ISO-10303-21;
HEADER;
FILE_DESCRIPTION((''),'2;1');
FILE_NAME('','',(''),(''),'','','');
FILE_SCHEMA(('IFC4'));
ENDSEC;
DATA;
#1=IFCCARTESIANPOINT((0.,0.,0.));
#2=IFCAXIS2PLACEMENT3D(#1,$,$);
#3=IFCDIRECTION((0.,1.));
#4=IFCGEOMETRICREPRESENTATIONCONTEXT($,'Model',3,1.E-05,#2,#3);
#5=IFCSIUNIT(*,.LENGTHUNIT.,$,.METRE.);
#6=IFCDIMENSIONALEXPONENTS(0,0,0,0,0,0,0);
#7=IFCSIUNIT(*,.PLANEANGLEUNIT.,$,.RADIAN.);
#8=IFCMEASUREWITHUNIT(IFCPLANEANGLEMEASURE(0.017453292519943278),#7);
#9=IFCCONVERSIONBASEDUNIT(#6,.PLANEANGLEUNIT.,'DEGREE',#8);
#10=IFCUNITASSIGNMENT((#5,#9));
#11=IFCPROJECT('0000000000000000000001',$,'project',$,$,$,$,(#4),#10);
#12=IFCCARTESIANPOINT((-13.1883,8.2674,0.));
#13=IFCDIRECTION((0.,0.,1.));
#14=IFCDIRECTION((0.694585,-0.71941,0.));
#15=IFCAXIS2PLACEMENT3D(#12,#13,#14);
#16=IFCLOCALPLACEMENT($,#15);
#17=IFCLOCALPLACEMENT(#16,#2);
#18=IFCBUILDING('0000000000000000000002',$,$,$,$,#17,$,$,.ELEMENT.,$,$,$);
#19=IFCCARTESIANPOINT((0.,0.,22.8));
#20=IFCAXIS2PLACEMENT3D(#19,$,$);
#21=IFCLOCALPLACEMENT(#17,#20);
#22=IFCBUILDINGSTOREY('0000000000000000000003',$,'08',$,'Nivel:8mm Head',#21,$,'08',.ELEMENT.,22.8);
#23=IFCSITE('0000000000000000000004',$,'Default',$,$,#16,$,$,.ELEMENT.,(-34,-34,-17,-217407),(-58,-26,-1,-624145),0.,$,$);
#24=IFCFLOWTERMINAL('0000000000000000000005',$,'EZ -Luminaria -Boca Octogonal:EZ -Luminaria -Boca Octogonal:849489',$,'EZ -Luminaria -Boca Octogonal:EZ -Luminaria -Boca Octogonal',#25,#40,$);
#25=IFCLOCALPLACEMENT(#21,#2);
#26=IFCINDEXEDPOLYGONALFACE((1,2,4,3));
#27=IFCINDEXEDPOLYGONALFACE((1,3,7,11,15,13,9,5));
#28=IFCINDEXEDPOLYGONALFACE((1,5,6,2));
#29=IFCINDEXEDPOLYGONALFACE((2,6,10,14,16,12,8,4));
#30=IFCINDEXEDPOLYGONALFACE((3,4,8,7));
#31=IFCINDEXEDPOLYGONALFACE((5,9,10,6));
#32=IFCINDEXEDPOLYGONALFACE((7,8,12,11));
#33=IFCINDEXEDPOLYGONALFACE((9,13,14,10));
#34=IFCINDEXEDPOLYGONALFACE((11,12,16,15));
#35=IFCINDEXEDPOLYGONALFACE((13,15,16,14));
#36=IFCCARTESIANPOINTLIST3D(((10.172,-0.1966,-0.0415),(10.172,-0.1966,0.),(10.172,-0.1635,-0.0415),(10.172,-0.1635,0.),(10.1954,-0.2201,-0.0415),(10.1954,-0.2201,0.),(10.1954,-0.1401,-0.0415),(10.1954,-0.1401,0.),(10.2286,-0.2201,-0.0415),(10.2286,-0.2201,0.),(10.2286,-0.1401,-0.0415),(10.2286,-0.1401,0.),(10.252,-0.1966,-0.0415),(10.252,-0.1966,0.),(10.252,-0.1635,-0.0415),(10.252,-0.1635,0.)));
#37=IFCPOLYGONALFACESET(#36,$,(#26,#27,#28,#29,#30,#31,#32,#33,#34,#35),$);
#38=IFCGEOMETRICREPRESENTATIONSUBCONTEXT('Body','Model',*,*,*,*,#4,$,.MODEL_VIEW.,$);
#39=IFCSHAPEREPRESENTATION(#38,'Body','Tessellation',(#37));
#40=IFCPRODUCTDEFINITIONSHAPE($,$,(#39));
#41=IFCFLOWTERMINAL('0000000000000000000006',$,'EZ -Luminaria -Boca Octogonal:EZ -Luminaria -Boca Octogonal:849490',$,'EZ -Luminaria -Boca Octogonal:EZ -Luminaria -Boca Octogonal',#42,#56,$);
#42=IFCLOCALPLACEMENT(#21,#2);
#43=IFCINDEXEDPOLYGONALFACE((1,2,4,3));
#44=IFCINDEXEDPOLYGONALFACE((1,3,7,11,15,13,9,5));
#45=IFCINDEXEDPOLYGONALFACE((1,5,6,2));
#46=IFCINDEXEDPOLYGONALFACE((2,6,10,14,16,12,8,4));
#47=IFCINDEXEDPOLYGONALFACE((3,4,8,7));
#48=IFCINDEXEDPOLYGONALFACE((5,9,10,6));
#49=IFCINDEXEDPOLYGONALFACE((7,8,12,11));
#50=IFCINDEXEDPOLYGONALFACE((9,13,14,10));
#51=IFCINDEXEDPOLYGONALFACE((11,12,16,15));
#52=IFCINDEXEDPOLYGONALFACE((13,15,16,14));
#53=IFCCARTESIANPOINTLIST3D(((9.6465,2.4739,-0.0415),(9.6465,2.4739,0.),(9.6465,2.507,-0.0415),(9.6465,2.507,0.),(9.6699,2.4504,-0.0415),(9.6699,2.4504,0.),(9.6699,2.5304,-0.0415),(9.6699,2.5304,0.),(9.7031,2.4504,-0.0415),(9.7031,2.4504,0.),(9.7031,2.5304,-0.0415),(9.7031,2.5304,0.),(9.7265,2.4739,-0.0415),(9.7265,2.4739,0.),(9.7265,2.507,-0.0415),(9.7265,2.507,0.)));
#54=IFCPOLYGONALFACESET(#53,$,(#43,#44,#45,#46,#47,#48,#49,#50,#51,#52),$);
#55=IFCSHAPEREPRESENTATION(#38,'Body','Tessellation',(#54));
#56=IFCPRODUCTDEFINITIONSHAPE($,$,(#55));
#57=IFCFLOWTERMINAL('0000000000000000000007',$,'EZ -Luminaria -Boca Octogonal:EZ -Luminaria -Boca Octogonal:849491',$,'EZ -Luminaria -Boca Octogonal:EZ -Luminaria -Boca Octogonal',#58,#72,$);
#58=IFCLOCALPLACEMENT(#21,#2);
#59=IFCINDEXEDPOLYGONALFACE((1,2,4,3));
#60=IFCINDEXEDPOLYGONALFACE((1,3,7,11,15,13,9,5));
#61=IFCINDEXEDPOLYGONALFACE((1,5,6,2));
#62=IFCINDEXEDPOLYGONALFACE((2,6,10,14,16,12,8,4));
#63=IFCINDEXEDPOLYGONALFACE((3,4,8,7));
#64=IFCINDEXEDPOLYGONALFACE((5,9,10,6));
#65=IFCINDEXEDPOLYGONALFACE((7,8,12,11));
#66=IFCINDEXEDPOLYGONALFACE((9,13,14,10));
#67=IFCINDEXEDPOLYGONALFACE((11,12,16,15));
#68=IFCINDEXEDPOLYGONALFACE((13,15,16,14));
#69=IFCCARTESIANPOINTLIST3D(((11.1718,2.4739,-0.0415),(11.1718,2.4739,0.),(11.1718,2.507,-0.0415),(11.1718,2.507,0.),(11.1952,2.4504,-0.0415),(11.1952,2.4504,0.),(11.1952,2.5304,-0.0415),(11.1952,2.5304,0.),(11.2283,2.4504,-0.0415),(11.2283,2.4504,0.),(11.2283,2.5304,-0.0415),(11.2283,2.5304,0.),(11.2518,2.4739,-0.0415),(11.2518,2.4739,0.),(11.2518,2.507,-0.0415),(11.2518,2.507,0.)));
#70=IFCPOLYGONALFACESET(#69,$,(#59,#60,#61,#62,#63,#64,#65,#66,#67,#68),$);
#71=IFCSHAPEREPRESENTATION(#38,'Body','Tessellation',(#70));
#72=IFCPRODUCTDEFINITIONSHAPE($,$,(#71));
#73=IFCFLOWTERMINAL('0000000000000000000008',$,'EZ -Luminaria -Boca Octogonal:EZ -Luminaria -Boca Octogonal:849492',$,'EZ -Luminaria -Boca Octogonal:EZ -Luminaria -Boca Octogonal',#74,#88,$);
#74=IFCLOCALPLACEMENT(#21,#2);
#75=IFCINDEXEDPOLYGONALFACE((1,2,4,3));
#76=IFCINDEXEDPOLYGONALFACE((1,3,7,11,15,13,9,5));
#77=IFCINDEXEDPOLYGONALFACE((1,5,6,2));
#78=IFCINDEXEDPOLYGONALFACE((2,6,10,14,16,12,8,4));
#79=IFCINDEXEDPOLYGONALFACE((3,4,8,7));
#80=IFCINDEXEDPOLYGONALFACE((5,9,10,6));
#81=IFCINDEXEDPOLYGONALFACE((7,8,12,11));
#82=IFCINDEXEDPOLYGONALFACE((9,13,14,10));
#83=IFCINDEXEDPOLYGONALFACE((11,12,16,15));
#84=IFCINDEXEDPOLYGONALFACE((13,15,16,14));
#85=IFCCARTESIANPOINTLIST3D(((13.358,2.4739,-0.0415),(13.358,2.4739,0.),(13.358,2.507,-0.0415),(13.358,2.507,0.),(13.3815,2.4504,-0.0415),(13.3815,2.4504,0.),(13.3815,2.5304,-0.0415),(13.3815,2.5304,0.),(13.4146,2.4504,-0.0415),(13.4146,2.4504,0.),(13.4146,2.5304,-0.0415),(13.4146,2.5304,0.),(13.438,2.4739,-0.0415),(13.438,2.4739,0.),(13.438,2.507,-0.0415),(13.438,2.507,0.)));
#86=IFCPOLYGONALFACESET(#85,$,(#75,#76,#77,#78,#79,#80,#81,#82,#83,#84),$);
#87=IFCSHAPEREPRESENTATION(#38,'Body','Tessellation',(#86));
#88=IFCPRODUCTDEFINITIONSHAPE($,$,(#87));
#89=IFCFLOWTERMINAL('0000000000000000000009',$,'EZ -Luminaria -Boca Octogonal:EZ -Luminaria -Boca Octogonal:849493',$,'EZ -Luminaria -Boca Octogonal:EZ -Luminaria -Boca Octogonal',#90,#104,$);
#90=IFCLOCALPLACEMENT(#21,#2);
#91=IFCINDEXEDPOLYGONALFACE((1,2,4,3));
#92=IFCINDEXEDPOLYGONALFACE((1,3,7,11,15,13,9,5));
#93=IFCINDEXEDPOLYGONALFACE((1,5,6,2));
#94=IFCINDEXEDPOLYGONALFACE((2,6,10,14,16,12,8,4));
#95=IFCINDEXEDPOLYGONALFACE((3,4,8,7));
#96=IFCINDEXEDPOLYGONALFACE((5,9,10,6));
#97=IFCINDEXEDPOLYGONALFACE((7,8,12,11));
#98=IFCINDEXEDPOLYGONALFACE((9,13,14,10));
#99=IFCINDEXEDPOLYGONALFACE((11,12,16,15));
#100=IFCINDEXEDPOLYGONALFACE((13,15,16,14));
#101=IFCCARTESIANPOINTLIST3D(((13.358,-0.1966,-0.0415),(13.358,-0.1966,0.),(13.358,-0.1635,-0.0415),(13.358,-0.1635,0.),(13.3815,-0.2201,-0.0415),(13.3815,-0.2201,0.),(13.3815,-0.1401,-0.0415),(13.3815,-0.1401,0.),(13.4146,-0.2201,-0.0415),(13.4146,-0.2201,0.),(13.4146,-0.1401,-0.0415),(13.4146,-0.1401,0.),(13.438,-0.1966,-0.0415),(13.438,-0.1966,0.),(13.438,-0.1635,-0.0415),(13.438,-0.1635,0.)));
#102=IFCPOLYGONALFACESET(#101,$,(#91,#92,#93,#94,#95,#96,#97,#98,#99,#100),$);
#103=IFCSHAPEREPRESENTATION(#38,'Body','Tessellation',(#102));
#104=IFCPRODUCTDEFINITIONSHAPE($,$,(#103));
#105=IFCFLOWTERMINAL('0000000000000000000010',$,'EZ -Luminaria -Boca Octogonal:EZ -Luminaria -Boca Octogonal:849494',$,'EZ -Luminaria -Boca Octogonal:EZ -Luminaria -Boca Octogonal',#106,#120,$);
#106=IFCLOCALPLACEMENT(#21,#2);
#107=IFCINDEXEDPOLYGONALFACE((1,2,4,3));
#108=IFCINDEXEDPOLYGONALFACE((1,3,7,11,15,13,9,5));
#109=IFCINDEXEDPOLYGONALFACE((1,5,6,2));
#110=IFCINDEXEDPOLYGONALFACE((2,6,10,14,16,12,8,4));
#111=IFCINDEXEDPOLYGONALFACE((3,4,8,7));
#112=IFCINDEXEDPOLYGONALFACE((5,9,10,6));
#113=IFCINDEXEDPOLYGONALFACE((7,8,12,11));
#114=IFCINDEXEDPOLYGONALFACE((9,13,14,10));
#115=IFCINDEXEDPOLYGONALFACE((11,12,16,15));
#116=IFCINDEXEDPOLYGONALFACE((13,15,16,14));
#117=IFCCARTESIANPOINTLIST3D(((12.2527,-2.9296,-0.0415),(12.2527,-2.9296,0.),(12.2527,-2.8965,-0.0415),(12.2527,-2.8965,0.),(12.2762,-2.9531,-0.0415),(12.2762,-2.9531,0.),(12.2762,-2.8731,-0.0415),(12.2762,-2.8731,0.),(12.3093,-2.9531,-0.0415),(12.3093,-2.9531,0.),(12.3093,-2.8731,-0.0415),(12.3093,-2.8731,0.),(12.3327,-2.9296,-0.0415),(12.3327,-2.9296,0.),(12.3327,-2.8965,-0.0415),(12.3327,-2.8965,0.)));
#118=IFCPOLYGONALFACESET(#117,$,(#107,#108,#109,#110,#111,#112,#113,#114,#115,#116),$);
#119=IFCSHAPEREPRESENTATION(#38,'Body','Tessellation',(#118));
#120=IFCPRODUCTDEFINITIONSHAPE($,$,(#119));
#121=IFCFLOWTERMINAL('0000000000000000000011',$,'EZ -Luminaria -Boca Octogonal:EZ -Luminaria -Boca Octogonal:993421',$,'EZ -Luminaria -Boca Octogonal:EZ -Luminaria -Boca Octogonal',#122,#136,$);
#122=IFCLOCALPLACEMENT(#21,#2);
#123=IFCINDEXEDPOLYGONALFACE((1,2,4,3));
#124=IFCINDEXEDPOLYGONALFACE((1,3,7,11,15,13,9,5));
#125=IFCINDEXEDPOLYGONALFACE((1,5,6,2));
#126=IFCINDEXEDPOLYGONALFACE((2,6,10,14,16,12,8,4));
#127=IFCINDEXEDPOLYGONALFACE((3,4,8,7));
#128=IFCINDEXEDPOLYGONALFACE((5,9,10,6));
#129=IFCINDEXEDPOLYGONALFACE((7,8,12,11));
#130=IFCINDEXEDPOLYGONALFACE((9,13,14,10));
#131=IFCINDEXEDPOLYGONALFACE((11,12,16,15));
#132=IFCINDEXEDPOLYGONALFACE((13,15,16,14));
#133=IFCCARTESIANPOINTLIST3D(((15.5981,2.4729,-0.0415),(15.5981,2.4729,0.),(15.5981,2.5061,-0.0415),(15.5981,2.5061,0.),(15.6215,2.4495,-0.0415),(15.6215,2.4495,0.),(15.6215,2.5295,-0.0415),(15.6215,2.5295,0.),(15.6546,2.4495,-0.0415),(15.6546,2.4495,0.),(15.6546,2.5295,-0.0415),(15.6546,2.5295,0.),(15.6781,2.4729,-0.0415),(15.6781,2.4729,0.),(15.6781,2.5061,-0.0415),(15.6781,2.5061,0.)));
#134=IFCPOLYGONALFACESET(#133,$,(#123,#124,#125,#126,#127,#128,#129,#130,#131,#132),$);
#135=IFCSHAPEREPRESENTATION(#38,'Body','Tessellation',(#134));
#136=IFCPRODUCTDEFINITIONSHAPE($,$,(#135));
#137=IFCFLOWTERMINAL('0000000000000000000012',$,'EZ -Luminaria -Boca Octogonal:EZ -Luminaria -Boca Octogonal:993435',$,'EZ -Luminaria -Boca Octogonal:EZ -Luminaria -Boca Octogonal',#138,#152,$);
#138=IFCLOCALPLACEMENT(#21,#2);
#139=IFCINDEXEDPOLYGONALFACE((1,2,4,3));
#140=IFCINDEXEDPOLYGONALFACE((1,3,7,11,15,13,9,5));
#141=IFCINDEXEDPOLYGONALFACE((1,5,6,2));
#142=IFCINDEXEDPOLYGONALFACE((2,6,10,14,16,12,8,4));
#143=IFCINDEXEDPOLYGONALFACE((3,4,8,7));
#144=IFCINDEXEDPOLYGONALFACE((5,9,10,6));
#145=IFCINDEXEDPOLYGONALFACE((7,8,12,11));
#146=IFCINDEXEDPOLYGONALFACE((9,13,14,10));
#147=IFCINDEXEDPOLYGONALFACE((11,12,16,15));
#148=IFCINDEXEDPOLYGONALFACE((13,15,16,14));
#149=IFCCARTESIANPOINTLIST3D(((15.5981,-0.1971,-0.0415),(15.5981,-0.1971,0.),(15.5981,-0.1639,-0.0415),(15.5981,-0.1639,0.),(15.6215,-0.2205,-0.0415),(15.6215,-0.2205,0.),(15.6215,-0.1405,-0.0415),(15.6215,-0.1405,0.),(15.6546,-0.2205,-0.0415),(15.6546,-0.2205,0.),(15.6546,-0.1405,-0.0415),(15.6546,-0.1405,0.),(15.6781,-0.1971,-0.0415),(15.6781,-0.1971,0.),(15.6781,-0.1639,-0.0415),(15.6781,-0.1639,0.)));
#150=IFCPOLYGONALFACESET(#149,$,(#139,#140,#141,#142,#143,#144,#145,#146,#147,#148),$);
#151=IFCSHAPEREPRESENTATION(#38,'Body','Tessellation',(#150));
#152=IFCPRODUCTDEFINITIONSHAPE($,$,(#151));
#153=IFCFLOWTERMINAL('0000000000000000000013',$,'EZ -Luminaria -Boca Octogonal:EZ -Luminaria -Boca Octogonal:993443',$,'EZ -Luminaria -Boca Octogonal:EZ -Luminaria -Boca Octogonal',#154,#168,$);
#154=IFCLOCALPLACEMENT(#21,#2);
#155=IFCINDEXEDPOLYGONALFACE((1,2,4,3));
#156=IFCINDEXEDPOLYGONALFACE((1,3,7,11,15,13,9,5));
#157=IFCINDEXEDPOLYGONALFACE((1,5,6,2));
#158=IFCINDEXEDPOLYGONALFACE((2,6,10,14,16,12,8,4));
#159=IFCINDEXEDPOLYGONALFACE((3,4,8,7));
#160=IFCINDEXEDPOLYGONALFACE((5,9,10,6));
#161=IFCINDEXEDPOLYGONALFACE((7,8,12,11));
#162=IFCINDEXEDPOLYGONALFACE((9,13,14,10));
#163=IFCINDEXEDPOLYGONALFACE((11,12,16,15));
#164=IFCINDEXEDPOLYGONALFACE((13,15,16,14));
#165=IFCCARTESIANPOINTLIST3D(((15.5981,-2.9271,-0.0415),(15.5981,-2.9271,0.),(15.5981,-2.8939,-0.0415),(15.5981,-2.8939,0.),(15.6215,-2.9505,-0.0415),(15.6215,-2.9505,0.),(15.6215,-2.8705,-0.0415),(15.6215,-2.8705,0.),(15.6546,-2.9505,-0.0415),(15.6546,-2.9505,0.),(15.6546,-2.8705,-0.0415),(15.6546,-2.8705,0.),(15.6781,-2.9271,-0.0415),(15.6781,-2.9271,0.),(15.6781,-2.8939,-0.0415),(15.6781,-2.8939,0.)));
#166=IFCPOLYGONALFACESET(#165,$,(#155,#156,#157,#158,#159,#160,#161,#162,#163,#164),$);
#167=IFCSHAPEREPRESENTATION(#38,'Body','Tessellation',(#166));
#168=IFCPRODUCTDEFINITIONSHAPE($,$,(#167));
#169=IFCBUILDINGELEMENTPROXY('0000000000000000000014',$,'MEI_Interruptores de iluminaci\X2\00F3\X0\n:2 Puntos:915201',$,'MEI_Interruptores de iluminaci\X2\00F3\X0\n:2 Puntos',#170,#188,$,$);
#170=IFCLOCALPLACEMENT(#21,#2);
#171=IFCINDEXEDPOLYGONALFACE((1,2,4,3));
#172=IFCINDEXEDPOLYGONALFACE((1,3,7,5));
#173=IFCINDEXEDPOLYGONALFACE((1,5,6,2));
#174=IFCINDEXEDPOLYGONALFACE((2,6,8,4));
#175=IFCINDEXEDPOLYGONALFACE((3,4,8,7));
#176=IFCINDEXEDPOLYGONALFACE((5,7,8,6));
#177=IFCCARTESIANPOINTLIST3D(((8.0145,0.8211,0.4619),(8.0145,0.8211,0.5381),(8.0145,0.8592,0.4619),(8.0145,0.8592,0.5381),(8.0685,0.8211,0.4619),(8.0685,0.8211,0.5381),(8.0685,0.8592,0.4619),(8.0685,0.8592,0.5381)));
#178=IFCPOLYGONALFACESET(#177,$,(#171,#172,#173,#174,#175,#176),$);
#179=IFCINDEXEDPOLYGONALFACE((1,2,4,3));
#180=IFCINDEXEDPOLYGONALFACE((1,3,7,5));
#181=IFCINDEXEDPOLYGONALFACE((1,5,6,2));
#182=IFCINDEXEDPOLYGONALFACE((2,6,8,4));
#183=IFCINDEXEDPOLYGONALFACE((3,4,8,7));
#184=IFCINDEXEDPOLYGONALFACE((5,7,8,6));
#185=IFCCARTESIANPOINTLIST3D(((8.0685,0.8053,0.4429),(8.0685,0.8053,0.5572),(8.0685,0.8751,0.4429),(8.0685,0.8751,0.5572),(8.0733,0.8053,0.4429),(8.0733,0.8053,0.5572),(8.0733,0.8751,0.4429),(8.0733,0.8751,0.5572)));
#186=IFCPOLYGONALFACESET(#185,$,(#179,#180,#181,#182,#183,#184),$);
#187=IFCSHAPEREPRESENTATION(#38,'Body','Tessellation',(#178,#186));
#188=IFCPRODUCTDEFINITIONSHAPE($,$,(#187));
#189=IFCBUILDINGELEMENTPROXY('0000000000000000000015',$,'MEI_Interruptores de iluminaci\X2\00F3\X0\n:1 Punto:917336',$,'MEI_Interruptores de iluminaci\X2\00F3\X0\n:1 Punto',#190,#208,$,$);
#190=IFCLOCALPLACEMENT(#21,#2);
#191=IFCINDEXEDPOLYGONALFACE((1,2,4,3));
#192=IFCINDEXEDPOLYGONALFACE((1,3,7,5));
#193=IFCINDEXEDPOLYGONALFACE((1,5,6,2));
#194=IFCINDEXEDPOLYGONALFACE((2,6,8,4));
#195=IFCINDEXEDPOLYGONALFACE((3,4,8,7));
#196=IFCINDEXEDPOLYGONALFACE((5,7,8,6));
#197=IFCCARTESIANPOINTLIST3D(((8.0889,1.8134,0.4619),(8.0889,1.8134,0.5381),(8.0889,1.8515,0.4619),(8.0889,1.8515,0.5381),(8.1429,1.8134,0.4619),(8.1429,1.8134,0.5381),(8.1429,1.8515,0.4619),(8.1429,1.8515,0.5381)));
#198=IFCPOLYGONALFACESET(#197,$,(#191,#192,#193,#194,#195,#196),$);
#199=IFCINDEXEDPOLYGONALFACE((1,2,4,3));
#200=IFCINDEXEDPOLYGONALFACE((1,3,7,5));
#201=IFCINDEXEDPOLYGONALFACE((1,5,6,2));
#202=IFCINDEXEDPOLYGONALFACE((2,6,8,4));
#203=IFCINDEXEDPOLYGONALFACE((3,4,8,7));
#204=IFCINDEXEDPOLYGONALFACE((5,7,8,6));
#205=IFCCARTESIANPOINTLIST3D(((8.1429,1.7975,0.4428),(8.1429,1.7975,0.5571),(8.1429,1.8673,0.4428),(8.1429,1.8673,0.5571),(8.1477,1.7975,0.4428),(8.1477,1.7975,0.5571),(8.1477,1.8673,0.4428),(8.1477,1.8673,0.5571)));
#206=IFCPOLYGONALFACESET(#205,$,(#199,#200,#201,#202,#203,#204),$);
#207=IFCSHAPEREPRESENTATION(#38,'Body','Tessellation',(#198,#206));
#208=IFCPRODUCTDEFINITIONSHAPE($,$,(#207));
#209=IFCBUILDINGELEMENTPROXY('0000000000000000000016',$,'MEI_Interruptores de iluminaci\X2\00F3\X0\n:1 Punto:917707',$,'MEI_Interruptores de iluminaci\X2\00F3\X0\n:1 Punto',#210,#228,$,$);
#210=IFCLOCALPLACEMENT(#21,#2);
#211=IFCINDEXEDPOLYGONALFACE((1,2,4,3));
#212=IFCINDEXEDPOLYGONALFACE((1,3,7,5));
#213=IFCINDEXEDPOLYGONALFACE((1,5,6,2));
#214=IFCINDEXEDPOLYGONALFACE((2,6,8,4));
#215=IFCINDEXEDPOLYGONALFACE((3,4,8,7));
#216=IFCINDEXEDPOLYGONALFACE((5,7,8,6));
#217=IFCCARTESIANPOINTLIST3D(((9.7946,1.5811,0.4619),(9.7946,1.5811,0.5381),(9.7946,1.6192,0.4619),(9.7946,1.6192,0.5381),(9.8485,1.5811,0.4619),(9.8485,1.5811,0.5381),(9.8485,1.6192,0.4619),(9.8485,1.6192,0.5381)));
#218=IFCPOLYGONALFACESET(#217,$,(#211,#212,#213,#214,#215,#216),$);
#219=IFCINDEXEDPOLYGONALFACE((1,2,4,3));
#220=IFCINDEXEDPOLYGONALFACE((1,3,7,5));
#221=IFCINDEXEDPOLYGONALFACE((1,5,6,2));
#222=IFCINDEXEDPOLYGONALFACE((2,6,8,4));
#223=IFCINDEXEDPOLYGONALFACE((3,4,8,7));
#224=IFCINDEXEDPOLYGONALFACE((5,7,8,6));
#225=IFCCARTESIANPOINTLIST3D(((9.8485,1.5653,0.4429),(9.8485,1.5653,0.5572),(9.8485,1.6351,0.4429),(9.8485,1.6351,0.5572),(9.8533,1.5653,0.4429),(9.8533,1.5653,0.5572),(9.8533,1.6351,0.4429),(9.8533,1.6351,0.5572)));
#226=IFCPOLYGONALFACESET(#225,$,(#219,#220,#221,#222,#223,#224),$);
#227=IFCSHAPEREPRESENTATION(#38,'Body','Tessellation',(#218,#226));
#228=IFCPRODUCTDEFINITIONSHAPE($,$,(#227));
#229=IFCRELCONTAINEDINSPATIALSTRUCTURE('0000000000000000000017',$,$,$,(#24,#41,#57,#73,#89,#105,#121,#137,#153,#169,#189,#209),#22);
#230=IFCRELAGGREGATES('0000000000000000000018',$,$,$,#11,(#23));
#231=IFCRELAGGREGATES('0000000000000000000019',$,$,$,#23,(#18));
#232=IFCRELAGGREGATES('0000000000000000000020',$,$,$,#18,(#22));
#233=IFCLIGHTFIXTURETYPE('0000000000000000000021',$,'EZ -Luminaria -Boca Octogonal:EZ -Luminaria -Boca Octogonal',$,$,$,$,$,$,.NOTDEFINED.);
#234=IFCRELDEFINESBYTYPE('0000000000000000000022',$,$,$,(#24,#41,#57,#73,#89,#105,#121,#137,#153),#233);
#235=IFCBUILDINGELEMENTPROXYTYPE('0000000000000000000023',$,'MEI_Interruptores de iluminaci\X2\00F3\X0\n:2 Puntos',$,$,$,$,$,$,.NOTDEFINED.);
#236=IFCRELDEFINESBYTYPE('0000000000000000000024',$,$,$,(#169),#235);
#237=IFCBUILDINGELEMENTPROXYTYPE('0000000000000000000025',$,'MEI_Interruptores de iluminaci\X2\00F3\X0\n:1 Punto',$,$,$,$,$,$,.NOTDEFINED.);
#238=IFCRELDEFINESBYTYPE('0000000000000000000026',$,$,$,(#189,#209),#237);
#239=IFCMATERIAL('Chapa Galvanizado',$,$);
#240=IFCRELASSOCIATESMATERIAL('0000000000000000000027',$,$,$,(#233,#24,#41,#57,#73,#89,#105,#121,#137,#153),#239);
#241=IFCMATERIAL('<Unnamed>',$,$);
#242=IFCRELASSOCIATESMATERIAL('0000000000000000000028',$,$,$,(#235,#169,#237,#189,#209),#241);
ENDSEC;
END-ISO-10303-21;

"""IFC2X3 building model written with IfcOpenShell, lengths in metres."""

from ifc_helpers import new_model, entity, si_unit, converted_unit, direction, frame, frame_2d, origin, origin_2d_with_axis, place, context, subcontext, project, spatial, polyline, rectangle, outline, extrude, source, transform, mapped, material, type_object, type_shapes, element, save


model = new_model("IFC2X3")

# Units and contexts
model_context = context("Model", 3, precision=1e-05, world=origin(), true_north=direction((0.0, 1.0)))
body_context = subcontext(model_context, "Body", "Model", "MODEL_VIEW")
ifc_project = project(units=[si_unit("LENGTHUNIT", "METRE"), converted_unit("PLANEANGLEUNIT", "DEGREE", entity("IfcPlaneAngleMeasure", 0.017453292519943278), si_unit("PLANEANGLEUNIT", "RADIAN"), dimensions=[0, 0, 0, 0, 0, 0, 0])], contexts=[model_context])

# Site, building, storey
site_placement = place(None, frame((-13.1883, 8.2674, 0.0), z_axis=(0.0, 0.0, 1.0), x_axis=(0.694585, -0.71941, 0.0)))
site = spatial("IfcSite", under=ifc_project, at=site_placement, Name="Default", CompositionType="ELEMENT", RefLatitude=(-34, -34, -17, -217407), RefLongitude=(-58, -26, -1, -624145), RefElevation=0.0)
building_placement = place(site_placement, origin())
building = spatial("IfcBuilding", under=site, at=building_placement, CompositionType="ELEMENT")
storey_placement = place(building_placement, frame((0.0, 0.0, 22.8)))
storey = spatial("IfcBuildingStorey", under=building, at=storey_placement, Name="08", ObjectType="Nivel:8mm Head", LongName="08", CompositionType="ELEMENT", Elevation=22.8)

# Flow terminals
ifc_material_1 = material(Name="Chapa Galvanizado")
light_fixture_type = type_object("IfcLightFixtureType", Name="EZ -Luminaria -Boca Octogonal:EZ -Luminaria -Boca Octogonal", PredefinedType="NOTDEFINED", material=ifc_material_1)
shared_shape_1 = source(origin(), body_context, "Body", "SweptSolid", [
    extrude(outline(polyline([(-0.0166, -0.04), (0.0166, -0.04), (0.04, -0.0166), (0.04, 0.0166), (0.0166, 0.04), (-0.0166, 0.04), (-0.04, 0.0166), (-0.04, -0.0166), (-0.0166, -0.04)])), frame((0.0, 0.0, -0.0415), z_axis=(0.0, 0.0, 1.0), x_axis=(0.0, -1.0, 0.0)), (0.0, 0.0, 1.0), 0.0415),
])
type_shapes(light_fixture_type, [shared_shape_1])
for number, where, name in (
    (1, (10.212, -0.1801, 0.0), "EZ -Luminaria -Boca Octogonal:EZ -Luminaria -Boca Octogonal:849489"),
    (2, (9.6865, 2.4904, 0.0), "EZ -Luminaria -Boca Octogonal:EZ -Luminaria -Boca Octogonal:849490"),
    (3, (11.2118, 2.4904, 0.0), "EZ -Luminaria -Boca Octogonal:EZ -Luminaria -Boca Octogonal:849491"),
    (4, (13.398, 2.4904, 0.0), "EZ -Luminaria -Boca Octogonal:EZ -Luminaria -Boca Octogonal:849492"),
    (5, (13.398, -0.1801, 0.0), "EZ -Luminaria -Boca Octogonal:EZ -Luminaria -Boca Octogonal:849493"),
    (6, (12.2927, -2.9131, 0.0), "EZ -Luminaria -Boca Octogonal:EZ -Luminaria -Boca Octogonal:849494"),
    (7, (15.6381, 2.4895, 0.0), "EZ -Luminaria -Boca Octogonal:EZ -Luminaria -Boca Octogonal:993421"),
    (8, (15.6381, -0.1805, 0.0), "EZ -Luminaria -Boca Octogonal:EZ -Luminaria -Boca Octogonal:993435"),
    (9, (15.6381, -2.9105, 0.0), "EZ -Luminaria -Boca Octogonal:EZ -Luminaria -Boca Octogonal:993443"),
):
    element("IfcFlowTerminal", number, at=place(storey_placement, frame(where)), inside=storey, type_object=light_fixture_type, material=ifc_material_1, Name=name, ObjectType="EZ -Luminaria -Boca Octogonal:EZ -Luminaria -Boca Octogonal", context=body_context, shape_type="MappedRepresentation", body=[
        mapped(shared_shape_1, transform((0.0, 0.0, 0.0), scale=1.0)),
    ])

# Building element proxies
ifc_material_2 = material(Name="<Unnamed>")
building_element_proxy_type_1 = type_object("IfcBuildingElementProxyType", Name="MEI_Interruptores de iluminación:2 Puntos", PredefinedType="NOTDEFINED", material=ifc_material_2)
shared_shape_2 = source(origin(), body_context, "Body", "SweptSolid", [
    extrude(rectangle(XDim=0.0381, YDim=0.0762, at=origin_2d_with_axis()), frame((0.0, 0.0, -0.054), z_axis=(0.0, 0.0, 1.0), x_axis=(-1.0, 0.0, 0.0)), (0.0, 0.0, 1.0), 0.054),
    extrude(rectangle(XDim=0.0698, YDim=0.1143, at=frame_2d((0.0, 0.0), x_axis=(1.0, 0.0))), frame((0.0, 0.0, 0.0), z_axis=(0.0, 0.0, 1.0), x_axis=(-1.0, 0.0, 0.0)), (0.0, 0.0, 1.0), 0.0048),
])
type_shapes(building_element_proxy_type_1, [shared_shape_2])
proxy_1_placement = place(storey_placement, frame((8.0685, 0.8402, 0.5), z_axis=(1.0, 0.0, 0.0), x_axis=(0.0, 1.0, 0.0)))
element("IfcBuildingElementProxy", 10, at=proxy_1_placement, inside=storey, type_object=building_element_proxy_type_1, material=ifc_material_2, Name="MEI_Interruptores de iluminación:2 Puntos:915201", ObjectType="MEI_Interruptores de iluminación:2 Puntos", context=body_context, shape_type="MappedRepresentation", body=[
    mapped(shared_shape_2, transform((0.0, 0.0, 0.0), scale=1.0)),
])
building_element_proxy_type_2 = type_object("IfcBuildingElementProxyType", Name="MEI_Interruptores de iluminación:1 Punto", PredefinedType="NOTDEFINED", material=ifc_material_2)
shared_shape_3 = source(origin(), body_context, "Body", "SweptSolid", [
    extrude(rectangle(XDim=0.0381, YDim=0.0762, at=origin_2d_with_axis()), frame((0.0, 0.0, -0.054), z_axis=(0.0, 0.0, 1.0), x_axis=(-1.0, 0.0, 0.0)), (0.0, 0.0, 1.0), 0.054),
    extrude(rectangle(XDim=0.0698, YDim=0.1143, at=frame_2d((0.0, 0.0), x_axis=(1.0, 0.0))), frame((0.0, 0.0, 0.0), z_axis=(0.0, 0.0, 1.0), x_axis=(-1.0, 0.0, 0.0)), (0.0, 0.0, 1.0), 0.0048),
])
type_shapes(building_element_proxy_type_2, [shared_shape_3])
for number, where, z_axis, x_axis, name in (
    (11, (8.1429, 1.8324, 0.5), (1.0, 0.0, 0.0), (0.0, -1.0, 0.0), "MEI_Interruptores de iluminación:1 Punto:917336"),
    (12, (9.8485, 1.6002, 0.5), (1.0, 0.0, 0.0), (0.0, 1.0, 0.0), "MEI_Interruptores de iluminación:1 Punto:917707"),
):
    element("IfcBuildingElementProxy", number, at=place(storey_placement, frame(where, z_axis=z_axis, x_axis=x_axis)), inside=storey, type_object=building_element_proxy_type_2, material=ifc_material_2, Name=name, ObjectType="MEI_Interruptores de iluminación:1 Punto", context=body_context, shape_type="MappedRepresentation", body=[
        mapped(shared_shape_3, transform((0.0, 0.0, 0.0), scale=1.0)),
    ])

save(model, "model.ifc")
